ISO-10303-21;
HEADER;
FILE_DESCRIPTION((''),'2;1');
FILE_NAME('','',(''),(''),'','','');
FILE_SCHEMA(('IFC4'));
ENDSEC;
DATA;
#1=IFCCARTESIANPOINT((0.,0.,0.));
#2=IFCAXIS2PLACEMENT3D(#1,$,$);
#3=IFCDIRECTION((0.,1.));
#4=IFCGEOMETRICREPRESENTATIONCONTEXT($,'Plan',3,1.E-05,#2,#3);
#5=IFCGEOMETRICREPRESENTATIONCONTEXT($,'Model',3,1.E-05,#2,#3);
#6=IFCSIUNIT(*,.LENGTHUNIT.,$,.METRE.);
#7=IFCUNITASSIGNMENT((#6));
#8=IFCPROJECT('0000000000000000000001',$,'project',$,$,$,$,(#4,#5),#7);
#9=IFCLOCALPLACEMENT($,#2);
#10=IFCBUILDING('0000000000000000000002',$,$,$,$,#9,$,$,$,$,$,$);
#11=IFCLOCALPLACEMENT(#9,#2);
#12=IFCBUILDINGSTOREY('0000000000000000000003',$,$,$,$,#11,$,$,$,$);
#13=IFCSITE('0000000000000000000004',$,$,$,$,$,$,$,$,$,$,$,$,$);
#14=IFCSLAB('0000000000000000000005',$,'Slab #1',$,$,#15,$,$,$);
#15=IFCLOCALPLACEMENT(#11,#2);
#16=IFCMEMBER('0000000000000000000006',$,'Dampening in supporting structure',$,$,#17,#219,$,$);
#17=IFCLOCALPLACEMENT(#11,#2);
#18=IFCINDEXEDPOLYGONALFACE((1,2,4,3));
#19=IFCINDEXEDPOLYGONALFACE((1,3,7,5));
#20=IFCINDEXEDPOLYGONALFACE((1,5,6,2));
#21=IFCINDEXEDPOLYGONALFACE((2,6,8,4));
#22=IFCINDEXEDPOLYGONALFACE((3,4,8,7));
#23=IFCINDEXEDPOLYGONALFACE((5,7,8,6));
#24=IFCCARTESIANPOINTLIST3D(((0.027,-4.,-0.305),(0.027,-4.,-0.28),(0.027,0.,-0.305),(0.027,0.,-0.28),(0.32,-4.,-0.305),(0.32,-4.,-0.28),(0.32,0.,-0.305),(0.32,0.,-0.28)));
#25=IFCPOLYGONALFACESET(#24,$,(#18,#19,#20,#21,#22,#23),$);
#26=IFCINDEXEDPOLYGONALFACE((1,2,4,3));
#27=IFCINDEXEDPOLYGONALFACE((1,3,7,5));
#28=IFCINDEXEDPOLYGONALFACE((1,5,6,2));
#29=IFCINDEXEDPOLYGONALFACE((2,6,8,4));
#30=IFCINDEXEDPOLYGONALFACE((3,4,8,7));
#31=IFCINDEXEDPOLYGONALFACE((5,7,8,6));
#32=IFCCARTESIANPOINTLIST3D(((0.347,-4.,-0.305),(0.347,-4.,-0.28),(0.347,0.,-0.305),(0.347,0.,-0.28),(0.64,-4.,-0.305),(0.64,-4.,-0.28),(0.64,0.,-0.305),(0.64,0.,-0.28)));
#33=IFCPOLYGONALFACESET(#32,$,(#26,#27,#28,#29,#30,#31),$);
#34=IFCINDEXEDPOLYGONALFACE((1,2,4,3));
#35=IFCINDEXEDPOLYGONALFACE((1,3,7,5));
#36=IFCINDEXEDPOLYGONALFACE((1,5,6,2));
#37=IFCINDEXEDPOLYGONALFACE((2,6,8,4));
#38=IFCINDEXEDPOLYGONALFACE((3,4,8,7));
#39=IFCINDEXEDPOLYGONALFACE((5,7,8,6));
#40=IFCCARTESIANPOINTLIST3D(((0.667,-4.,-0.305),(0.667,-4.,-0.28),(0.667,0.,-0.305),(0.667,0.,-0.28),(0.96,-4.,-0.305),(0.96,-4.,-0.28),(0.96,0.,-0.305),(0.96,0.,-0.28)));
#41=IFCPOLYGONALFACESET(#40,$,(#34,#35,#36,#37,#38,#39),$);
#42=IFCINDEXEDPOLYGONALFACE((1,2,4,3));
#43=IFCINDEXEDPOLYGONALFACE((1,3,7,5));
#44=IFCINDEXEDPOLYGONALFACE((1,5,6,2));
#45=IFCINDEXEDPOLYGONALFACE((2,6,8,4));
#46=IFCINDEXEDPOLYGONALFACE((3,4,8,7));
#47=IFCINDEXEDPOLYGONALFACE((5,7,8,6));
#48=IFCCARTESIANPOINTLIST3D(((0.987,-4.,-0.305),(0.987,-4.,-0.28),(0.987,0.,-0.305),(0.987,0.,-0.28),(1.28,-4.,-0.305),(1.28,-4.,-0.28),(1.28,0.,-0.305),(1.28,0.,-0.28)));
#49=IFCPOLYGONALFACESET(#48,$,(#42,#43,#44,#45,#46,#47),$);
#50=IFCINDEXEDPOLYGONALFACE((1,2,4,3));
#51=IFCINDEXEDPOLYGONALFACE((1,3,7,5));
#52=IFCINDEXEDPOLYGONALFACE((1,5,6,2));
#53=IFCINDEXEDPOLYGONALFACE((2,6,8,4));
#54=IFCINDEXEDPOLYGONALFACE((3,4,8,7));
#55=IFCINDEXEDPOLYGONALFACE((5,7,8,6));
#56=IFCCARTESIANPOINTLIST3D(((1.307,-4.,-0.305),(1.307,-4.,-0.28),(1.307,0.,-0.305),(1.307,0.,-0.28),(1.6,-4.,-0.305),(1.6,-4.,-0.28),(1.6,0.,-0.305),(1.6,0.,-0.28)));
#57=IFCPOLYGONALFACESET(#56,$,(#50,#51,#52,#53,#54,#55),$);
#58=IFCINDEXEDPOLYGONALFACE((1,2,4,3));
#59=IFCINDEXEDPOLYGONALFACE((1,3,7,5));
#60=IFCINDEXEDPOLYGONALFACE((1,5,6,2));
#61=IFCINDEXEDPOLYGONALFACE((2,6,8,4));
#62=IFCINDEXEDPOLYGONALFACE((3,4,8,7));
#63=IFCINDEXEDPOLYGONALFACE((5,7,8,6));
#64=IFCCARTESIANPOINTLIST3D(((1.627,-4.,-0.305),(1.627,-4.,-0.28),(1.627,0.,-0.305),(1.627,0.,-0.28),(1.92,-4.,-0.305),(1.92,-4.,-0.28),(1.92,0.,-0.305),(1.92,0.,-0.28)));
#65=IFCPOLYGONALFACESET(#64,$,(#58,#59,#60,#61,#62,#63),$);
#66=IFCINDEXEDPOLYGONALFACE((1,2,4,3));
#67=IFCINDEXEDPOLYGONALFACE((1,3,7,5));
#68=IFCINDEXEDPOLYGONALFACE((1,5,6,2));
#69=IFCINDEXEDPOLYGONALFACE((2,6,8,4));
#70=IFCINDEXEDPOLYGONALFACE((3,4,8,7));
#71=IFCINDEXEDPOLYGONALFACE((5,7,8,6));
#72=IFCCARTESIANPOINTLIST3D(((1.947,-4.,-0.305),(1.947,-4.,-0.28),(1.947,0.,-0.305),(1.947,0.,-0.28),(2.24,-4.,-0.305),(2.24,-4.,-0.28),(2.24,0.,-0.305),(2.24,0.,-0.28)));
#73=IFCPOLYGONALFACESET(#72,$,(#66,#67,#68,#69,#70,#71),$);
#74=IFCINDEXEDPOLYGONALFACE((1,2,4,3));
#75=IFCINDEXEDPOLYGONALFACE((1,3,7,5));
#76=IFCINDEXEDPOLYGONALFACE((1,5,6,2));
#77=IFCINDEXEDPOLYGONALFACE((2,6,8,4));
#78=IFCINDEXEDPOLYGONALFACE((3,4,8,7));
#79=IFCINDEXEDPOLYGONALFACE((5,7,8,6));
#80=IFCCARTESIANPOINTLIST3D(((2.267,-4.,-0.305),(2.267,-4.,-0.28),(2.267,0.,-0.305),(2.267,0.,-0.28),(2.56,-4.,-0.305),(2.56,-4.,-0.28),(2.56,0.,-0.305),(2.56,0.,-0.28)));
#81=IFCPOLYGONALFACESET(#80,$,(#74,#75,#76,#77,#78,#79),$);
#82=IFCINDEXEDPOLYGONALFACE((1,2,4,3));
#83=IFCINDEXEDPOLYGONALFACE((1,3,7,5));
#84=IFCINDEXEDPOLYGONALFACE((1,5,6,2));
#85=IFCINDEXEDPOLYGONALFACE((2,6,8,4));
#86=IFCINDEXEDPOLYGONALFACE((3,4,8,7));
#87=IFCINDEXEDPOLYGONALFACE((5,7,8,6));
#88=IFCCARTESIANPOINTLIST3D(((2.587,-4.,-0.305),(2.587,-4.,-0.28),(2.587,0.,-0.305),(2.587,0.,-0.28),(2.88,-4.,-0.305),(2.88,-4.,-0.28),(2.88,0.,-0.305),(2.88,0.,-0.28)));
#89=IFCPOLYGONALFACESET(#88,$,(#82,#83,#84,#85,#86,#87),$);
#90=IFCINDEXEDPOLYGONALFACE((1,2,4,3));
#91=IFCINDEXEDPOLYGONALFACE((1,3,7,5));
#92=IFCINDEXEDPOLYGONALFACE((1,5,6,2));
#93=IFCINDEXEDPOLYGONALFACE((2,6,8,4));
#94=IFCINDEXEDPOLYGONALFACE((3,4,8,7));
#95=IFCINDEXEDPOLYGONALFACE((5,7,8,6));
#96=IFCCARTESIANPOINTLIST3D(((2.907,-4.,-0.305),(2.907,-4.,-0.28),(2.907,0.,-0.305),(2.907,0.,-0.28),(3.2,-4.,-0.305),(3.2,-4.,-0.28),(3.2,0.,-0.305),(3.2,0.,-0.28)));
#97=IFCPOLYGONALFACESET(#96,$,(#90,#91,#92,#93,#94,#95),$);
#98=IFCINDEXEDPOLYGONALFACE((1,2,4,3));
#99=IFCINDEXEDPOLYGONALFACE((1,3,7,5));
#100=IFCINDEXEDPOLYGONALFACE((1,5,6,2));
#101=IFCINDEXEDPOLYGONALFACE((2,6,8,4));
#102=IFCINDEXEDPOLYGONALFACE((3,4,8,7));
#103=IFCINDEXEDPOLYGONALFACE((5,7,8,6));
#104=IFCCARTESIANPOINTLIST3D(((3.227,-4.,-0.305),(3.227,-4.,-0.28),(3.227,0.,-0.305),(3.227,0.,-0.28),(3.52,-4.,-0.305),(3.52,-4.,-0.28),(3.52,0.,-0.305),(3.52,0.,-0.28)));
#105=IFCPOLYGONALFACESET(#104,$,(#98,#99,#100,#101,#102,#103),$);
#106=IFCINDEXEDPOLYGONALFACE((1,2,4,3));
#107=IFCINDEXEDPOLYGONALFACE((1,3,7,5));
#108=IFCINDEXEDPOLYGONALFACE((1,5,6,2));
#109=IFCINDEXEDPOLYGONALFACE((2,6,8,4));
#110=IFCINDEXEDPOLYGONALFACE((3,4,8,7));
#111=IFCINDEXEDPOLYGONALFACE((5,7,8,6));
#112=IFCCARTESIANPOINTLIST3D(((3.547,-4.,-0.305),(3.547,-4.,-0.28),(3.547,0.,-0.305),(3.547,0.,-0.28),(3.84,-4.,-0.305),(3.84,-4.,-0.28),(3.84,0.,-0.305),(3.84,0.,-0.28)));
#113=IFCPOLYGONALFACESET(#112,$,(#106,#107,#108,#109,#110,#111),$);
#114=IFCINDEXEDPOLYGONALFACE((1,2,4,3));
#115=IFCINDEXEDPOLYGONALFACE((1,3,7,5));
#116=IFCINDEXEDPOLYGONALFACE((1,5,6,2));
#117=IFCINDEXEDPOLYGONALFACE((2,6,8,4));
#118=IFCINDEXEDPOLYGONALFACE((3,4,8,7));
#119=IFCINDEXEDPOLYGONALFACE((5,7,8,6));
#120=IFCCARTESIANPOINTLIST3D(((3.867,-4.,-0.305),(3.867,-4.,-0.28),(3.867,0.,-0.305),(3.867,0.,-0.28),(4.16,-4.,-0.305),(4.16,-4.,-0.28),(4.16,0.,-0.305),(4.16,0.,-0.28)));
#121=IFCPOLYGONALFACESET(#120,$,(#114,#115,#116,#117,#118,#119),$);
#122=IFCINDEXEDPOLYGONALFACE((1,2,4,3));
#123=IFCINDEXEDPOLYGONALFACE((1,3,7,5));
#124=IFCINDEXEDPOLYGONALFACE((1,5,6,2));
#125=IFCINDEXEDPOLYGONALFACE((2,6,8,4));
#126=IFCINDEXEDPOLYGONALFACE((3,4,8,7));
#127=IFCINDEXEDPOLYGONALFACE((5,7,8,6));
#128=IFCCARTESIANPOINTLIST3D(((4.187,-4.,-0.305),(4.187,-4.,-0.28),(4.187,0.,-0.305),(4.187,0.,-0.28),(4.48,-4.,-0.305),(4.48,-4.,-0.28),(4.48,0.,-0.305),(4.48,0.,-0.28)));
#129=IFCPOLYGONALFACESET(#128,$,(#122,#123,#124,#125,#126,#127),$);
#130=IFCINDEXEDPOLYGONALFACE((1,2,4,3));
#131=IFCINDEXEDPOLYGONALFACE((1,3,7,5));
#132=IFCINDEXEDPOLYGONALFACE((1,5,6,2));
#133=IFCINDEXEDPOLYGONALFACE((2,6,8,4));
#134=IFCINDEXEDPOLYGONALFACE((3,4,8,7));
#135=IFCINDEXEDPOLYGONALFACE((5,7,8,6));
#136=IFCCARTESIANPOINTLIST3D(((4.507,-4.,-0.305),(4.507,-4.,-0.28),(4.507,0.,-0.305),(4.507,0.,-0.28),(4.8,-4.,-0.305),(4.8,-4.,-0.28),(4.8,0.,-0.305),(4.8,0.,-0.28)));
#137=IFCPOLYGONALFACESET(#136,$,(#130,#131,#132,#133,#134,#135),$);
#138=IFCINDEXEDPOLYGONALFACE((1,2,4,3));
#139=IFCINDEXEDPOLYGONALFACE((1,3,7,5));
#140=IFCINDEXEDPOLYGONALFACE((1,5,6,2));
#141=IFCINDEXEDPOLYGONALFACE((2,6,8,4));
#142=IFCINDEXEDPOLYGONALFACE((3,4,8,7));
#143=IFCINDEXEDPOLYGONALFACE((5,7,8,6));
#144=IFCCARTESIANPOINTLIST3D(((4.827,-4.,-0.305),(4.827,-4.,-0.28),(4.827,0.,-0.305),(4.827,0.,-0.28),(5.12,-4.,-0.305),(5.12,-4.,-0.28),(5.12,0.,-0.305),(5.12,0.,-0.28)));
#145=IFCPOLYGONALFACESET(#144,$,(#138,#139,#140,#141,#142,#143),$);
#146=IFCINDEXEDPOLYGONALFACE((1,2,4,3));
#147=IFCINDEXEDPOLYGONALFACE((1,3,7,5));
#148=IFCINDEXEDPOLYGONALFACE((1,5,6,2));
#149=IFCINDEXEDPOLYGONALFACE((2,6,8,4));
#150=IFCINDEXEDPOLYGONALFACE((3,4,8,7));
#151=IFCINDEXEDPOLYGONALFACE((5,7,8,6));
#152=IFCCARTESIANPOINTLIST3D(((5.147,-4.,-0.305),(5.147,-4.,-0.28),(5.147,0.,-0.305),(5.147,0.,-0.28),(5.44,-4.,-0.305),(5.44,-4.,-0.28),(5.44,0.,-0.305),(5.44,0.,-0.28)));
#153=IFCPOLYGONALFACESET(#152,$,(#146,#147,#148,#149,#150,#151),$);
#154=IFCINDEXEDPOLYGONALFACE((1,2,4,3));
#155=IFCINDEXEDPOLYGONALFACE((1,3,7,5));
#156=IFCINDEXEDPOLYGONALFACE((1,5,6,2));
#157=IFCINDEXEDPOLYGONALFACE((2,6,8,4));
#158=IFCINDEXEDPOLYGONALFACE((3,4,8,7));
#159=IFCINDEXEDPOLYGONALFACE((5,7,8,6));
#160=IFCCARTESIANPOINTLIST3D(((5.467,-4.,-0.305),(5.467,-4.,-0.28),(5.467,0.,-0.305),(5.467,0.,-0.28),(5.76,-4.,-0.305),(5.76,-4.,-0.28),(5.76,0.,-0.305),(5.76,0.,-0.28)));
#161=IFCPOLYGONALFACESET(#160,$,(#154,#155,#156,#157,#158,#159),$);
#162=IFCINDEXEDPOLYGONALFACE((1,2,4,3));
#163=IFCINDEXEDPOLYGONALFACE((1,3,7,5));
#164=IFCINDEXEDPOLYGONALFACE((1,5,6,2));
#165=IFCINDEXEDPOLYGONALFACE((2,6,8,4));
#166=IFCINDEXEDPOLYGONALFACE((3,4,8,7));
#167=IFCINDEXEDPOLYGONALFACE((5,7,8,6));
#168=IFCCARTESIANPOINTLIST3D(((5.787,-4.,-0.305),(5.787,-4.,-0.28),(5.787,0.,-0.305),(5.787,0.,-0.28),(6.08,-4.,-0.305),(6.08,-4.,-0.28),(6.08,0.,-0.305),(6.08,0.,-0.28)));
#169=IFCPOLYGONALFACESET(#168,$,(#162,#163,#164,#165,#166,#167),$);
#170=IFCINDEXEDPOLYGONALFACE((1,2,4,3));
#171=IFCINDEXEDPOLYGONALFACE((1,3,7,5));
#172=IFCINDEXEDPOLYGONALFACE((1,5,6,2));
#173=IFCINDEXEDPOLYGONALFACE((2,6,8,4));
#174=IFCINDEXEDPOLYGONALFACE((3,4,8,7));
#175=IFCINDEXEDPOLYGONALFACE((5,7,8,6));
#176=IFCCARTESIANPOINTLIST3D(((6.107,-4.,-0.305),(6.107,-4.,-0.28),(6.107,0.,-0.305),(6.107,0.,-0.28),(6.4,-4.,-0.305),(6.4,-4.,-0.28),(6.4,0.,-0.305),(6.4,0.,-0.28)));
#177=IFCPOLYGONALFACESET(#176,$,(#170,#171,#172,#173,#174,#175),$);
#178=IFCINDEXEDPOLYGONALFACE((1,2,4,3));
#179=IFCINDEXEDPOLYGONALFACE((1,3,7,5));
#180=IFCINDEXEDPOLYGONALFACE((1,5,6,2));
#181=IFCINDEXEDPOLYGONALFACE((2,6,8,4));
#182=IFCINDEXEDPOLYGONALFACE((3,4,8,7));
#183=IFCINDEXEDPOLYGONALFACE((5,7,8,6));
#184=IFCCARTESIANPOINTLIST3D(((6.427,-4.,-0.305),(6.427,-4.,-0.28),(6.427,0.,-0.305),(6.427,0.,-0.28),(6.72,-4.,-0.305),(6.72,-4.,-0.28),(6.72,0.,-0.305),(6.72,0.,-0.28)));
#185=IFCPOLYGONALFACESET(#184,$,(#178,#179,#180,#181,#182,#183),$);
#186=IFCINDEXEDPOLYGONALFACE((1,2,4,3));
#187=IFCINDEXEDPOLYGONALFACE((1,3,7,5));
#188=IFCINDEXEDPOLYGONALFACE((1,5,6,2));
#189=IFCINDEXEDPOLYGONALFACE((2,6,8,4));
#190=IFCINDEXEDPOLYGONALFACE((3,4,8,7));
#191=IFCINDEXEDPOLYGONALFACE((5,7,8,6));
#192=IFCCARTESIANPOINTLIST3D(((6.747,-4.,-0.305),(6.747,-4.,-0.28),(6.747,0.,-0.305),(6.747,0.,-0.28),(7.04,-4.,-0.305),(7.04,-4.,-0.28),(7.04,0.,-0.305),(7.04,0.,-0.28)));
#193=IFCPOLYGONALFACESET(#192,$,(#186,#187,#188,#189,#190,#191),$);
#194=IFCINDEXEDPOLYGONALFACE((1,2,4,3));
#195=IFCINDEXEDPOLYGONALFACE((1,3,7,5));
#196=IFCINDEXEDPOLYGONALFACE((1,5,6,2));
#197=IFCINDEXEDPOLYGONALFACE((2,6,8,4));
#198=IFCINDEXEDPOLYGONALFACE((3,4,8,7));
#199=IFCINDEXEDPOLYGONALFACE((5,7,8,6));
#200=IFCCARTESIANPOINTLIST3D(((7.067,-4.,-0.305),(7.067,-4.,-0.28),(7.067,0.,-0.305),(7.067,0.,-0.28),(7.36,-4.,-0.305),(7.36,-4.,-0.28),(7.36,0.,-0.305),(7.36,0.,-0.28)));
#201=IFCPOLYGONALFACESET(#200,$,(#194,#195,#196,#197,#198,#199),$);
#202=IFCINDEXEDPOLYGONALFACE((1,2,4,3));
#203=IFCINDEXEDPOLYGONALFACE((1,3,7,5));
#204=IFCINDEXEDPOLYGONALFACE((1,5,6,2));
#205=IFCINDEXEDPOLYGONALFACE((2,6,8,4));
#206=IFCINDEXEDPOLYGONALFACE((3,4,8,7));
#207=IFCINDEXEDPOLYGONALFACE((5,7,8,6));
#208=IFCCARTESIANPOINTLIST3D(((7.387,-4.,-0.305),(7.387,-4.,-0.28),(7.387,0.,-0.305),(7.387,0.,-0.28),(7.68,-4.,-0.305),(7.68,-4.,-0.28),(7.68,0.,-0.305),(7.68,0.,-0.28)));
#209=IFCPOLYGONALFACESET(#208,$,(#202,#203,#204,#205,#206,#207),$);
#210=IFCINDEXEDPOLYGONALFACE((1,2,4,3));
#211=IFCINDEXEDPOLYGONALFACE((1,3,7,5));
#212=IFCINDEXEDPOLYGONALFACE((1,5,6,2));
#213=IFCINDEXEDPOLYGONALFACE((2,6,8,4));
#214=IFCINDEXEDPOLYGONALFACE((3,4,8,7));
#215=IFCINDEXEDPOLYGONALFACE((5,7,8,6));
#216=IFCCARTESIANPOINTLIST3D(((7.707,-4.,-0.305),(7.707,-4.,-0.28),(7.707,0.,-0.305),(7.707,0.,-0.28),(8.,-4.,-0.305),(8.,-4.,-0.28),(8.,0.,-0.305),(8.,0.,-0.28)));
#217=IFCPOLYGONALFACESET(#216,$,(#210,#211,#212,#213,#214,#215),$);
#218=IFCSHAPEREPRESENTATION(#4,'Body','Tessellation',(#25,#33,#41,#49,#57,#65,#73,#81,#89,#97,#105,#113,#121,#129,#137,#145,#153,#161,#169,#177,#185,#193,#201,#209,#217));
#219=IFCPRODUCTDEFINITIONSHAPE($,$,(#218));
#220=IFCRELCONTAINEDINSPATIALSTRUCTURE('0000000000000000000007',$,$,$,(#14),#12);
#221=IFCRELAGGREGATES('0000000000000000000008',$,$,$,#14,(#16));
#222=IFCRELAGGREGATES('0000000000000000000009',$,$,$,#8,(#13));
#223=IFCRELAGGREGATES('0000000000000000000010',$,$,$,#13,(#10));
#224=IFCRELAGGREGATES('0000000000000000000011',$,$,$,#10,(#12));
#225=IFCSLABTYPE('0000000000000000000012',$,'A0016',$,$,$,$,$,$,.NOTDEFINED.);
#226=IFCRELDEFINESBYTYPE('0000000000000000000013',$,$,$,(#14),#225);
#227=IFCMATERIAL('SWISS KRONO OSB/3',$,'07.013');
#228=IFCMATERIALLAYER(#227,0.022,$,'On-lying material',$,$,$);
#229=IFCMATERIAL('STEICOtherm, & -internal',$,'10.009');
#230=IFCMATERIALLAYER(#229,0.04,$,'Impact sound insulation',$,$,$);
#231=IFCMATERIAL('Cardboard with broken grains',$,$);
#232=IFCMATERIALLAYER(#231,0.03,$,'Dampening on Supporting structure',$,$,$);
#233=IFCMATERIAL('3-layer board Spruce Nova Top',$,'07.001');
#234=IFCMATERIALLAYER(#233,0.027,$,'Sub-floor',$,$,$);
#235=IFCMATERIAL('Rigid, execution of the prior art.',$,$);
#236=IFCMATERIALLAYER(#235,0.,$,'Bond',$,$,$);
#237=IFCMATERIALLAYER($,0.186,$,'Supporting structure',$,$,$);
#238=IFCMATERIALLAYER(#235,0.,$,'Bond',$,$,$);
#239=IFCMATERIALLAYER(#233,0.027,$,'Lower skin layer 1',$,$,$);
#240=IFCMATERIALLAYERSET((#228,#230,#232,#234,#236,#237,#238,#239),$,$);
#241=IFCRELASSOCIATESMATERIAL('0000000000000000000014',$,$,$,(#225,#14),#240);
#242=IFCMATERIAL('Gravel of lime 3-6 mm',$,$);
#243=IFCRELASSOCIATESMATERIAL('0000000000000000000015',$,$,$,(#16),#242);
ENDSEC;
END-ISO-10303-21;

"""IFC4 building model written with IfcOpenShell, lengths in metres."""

from ifc_helpers import new_model, si_unit, direction, frame, frame_2d, origin, place, context, project, spatial, rectangle, extrude, material, layer, layer_set, type_object, element, aggregate, save


model = new_model("IFC4")

# Units and contexts
plan_context = context("Plan", 3, precision=1e-05, world=origin(), true_north=direction((0.0, 1.0)))
model_context = context("Model", 3, precision=1e-05, world=origin(), true_north=direction((0.0, 1.0)))
ifc_project = project(units=[si_unit("LENGTHUNIT", "METRE")], contexts=[plan_context, model_context])

# Site, building, storey
site = spatial("IfcSite", under=ifc_project)
building_placement = place(None, origin())
building = spatial("IfcBuilding", under=site, at=building_placement)
storey_placement = place(building_placement, origin())
storey = spatial("IfcBuildingStorey", under=building, at=storey_placement)

# Slab, member
ifc_material_1 = material(Name="SWISS KRONO OSB/3", Category="07.013")
ifc_layer_1 = layer(ifc_material_1, 0.022, Name="On-lying material")
ifc_material_2 = material(Name="STEICOtherm, & -internal", Category="10.009")
ifc_layer_2 = layer(ifc_material_2, 0.04, Name="Impact sound insulation")
ifc_material_3 = material(Name="Cardboard with broken grains")
ifc_layer_3 = layer(ifc_material_3, 0.03, Name="Dampening on Supporting structure")
ifc_material_4 = material(Name="3-layer board Spruce Nova Top", Category="07.001")
ifc_layer_4 = layer(ifc_material_4, 0.027, Name="Sub-floor")
ifc_material_5 = material(Name="Rigid, execution of the prior art.")
ifc_layer_5 = layer(ifc_material_5, 0.0, Name="Bond")
ifc_layer_6 = layer(None, 0.186, Name="Supporting structure")
ifc_layer_7 = layer(ifc_material_5, 0.0, Name="Bond")
ifc_layer_8 = layer(ifc_material_4, 0.027, Name="Lower skin layer 1")
ifc_layer_set = layer_set([ifc_layer_1, ifc_layer_2, ifc_layer_3, ifc_layer_4, ifc_layer_5, ifc_layer_6, ifc_layer_7, ifc_layer_8])
slab_type = type_object("IfcSlabType", Name="A0016", PredefinedType="NOTDEFINED", material=ifc_layer_set)
slab_placement = place(None, frame((0.0, 0.0, 0.0), z_axis=(0.0, 0.0, -1.0), x_axis=(1.0, 0.0, 0.0)))
slab = element("IfcSlab", 1, at=slab_placement, inside=storey, type_object=slab_type, material=ifc_layer_set, Name="Slab #1")
ifc_material_6 = material(Name="Gravel of lime 3-6 mm")
member_1_placement = place(slab_placement, origin())
member_1 = element("IfcMember", 2, at=member_1_placement, material=ifc_material_6, Name="Dampening in supporting structure", context=plan_context, shape_type="SweptSolid", body=[
    extrude(rectangle(XDim=0.293, YDim=0.025, at=frame_2d((0.1465, 0.0125), x_axis=(1.0, 0.0))), frame((0.027, 4.0, 0.28), z_axis=(0.0, -1.0, 0.0), x_axis=(1.0, 0.0, 0.0)), (0.0, 0.0, 1.0), 4.0),
    extrude(rectangle(XDim=0.293, YDim=0.025, at=frame_2d((0.1465, 0.0125), x_axis=(1.0, 0.0))), frame((0.347, 4.0, 0.28), z_axis=(0.0, -1.0, 0.0), x_axis=(1.0, 0.0, 0.0)), (0.0, 0.0, 1.0), 4.0),
    extrude(rectangle(XDim=0.293, YDim=0.025, at=frame_2d((0.1465, 0.0125), x_axis=(1.0, 0.0))), frame((0.667, 4.0, 0.28), z_axis=(0.0, -1.0, 0.0), x_axis=(1.0, 0.0, 0.0)), (0.0, 0.0, 1.0), 4.0),
    extrude(rectangle(XDim=0.293, YDim=0.025, at=frame_2d((0.1465, 0.0125), x_axis=(1.0, 0.0))), frame((0.987, 4.0, 0.28), z_axis=(0.0, -1.0, 0.0), x_axis=(1.0, 0.0, 0.0)), (0.0, 0.0, 1.0), 4.0),
    extrude(rectangle(XDim=0.293, YDim=0.025, at=frame_2d((0.1465, 0.0125), x_axis=(1.0, 0.0))), frame((1.307, 4.0, 0.28), z_axis=(0.0, -1.0, 0.0), x_axis=(1.0, 0.0, 0.0)), (0.0, 0.0, 1.0), 4.0),
    extrude(rectangle(XDim=0.293, YDim=0.025, at=frame_2d((0.1465, 0.0125), x_axis=(1.0, 0.0))), frame((1.627, 4.0, 0.28), z_axis=(0.0, -1.0, 0.0), x_axis=(1.0, 0.0, 0.0)), (0.0, 0.0, 1.0), 4.0),
    extrude(rectangle(XDim=0.293, YDim=0.025, at=frame_2d((0.1465, 0.0125), x_axis=(1.0, 0.0))), frame((1.947, 4.0, 0.28), z_axis=(0.0, -1.0, 0.0), x_axis=(1.0, 0.0, 0.0)), (0.0, 0.0, 1.0), 4.0),
    extrude(rectangle(XDim=0.293, YDim=0.025, at=frame_2d((0.1465, 0.0125), x_axis=(1.0, 0.0))), frame((2.267, 4.0, 0.28), z_axis=(0.0, -1.0, 0.0), x_axis=(1.0, 0.0, 0.0)), (0.0, 0.0, 1.0), 4.0),
    extrude(rectangle(XDim=0.293, YDim=0.025, at=frame_2d((0.1465, 0.0125), x_axis=(1.0, 0.0))), frame((2.587, 4.0, 0.28), z_axis=(0.0, -1.0, 0.0), x_axis=(1.0, 0.0, 0.0)), (0.0, 0.0, 1.0), 4.0),
    extrude(rectangle(XDim=0.293, YDim=0.025, at=frame_2d((0.1465, 0.0125), x_axis=(1.0, 0.0))), frame((2.907, 4.0, 0.28), z_axis=(0.0, -1.0, 0.0), x_axis=(1.0, 0.0, 0.0)), (0.0, 0.0, 1.0), 4.0),
    extrude(rectangle(XDim=0.293, YDim=0.025, at=frame_2d((0.1465, 0.0125), x_axis=(1.0, 0.0))), frame((3.227, 4.0, 0.28), z_axis=(0.0, -1.0, 0.0), x_axis=(1.0, 0.0, 0.0)), (0.0, 0.0, 1.0), 4.0),
    extrude(rectangle(XDim=0.293, YDim=0.025, at=frame_2d((0.1465, 0.0125), x_axis=(1.0, 0.0))), frame((3.547, 4.0, 0.28), z_axis=(0.0, -1.0, 0.0), x_axis=(1.0, 0.0, 0.0)), (0.0, 0.0, 1.0), 4.0),
    extrude(rectangle(XDim=0.293, YDim=0.025, at=frame_2d((0.1465, 0.0125), x_axis=(1.0, 0.0))), frame((3.867, 4.0, 0.28), z_axis=(0.0, -1.0, 0.0), x_axis=(1.0, 0.0, 0.0)), (0.0, 0.0, 1.0), 4.0),
    extrude(rectangle(XDim=0.293, YDim=0.025, at=frame_2d((0.1465, 0.0125), x_axis=(1.0, 0.0))), frame((4.187, 4.0, 0.28), z_axis=(0.0, -1.0, 0.0), x_axis=(1.0, 0.0, 0.0)), (0.0, 0.0, 1.0), 4.0),
    extrude(rectangle(XDim=0.293, YDim=0.025, at=frame_2d((0.1465, 0.0125), x_axis=(1.0, 0.0))), frame((4.507, 4.0, 0.28), z_axis=(0.0, -1.0, 0.0), x_axis=(1.0, 0.0, 0.0)), (0.0, 0.0, 1.0), 4.0),
    extrude(rectangle(XDim=0.293, YDim=0.025, at=frame_2d((0.1465, 0.0125), x_axis=(1.0, 0.0))), frame((4.827, 4.0, 0.28), z_axis=(0.0, -1.0, 0.0), x_axis=(1.0, 0.0, 0.0)), (0.0, 0.0, 1.0), 4.0),
    extrude(rectangle(XDim=0.293, YDim=0.025, at=frame_2d((0.1465, 0.0125), x_axis=(1.0, 0.0))), frame((5.147, 4.0, 0.28), z_axis=(0.0, -1.0, 0.0), x_axis=(1.0, 0.0, 0.0)), (0.0, 0.0, 1.0), 4.0),
    extrude(rectangle(XDim=0.293, YDim=0.025, at=frame_2d((0.1465, 0.0125), x_axis=(1.0, 0.0))), frame((5.467, 4.0, 0.28), z_axis=(0.0, -1.0, 0.0), x_axis=(1.0, 0.0, 0.0)), (0.0, 0.0, 1.0), 4.0),
    extrude(rectangle(XDim=0.293, YDim=0.025, at=frame_2d((0.1465, 0.0125), x_axis=(1.0, 0.0))), frame((5.787, 4.0, 0.28), z_axis=(0.0, -1.0, 0.0), x_axis=(1.0, 0.0, 0.0)), (0.0, 0.0, 1.0), 4.0),
    extrude(rectangle(XDim=0.293, YDim=0.025, at=frame_2d((0.1465, 0.0125), x_axis=(1.0, 0.0))), frame((6.107, 4.0, 0.28), z_axis=(0.0, -1.0, 0.0), x_axis=(1.0, 0.0, 0.0)), (0.0, 0.0, 1.0), 4.0),
    extrude(rectangle(XDim=0.293, YDim=0.025, at=frame_2d((0.1465, 0.0125), x_axis=(1.0, 0.0))), frame((6.427, 4.0, 0.28), z_axis=(0.0, -1.0, 0.0), x_axis=(1.0, 0.0, 0.0)), (0.0, 0.0, 1.0), 4.0),
    extrude(rectangle(XDim=0.293, YDim=0.025, at=frame_2d((0.1465, 0.0125), x_axis=(1.0, 0.0))), frame((6.747, 4.0, 0.28), z_axis=(0.0, -1.0, 0.0), x_axis=(1.0, 0.0, 0.0)), (0.0, 0.0, 1.0), 4.0),
    extrude(rectangle(XDim=0.293, YDim=0.025, at=frame_2d((0.1465, 0.0125), x_axis=(1.0, 0.0))), frame((7.067, 4.0, 0.28), z_axis=(0.0, -1.0, 0.0), x_axis=(1.0, 0.0, 0.0)), (0.0, 0.0, 1.0), 4.0),
    extrude(rectangle(XDim=0.293, YDim=0.025, at=frame_2d((0.1465, 0.0125), x_axis=(1.0, 0.0))), frame((7.387, 4.0, 0.28), z_axis=(0.0, -1.0, 0.0), x_axis=(1.0, 0.0, 0.0)), (0.0, 0.0, 1.0), 4.0),
    extrude(rectangle(XDim=0.293, YDim=0.025, at=frame_2d((0.1465, 0.0125), x_axis=(1.0, 0.0))), frame((7.707, 4.0, 0.28), z_axis=(0.0, -1.0, 0.0), x_axis=(1.0, 0.0, 0.0)), (0.0, 0.0, 1.0), 4.0),
])
aggregate(slab, [member_1])

save(model, "model.ifc")
